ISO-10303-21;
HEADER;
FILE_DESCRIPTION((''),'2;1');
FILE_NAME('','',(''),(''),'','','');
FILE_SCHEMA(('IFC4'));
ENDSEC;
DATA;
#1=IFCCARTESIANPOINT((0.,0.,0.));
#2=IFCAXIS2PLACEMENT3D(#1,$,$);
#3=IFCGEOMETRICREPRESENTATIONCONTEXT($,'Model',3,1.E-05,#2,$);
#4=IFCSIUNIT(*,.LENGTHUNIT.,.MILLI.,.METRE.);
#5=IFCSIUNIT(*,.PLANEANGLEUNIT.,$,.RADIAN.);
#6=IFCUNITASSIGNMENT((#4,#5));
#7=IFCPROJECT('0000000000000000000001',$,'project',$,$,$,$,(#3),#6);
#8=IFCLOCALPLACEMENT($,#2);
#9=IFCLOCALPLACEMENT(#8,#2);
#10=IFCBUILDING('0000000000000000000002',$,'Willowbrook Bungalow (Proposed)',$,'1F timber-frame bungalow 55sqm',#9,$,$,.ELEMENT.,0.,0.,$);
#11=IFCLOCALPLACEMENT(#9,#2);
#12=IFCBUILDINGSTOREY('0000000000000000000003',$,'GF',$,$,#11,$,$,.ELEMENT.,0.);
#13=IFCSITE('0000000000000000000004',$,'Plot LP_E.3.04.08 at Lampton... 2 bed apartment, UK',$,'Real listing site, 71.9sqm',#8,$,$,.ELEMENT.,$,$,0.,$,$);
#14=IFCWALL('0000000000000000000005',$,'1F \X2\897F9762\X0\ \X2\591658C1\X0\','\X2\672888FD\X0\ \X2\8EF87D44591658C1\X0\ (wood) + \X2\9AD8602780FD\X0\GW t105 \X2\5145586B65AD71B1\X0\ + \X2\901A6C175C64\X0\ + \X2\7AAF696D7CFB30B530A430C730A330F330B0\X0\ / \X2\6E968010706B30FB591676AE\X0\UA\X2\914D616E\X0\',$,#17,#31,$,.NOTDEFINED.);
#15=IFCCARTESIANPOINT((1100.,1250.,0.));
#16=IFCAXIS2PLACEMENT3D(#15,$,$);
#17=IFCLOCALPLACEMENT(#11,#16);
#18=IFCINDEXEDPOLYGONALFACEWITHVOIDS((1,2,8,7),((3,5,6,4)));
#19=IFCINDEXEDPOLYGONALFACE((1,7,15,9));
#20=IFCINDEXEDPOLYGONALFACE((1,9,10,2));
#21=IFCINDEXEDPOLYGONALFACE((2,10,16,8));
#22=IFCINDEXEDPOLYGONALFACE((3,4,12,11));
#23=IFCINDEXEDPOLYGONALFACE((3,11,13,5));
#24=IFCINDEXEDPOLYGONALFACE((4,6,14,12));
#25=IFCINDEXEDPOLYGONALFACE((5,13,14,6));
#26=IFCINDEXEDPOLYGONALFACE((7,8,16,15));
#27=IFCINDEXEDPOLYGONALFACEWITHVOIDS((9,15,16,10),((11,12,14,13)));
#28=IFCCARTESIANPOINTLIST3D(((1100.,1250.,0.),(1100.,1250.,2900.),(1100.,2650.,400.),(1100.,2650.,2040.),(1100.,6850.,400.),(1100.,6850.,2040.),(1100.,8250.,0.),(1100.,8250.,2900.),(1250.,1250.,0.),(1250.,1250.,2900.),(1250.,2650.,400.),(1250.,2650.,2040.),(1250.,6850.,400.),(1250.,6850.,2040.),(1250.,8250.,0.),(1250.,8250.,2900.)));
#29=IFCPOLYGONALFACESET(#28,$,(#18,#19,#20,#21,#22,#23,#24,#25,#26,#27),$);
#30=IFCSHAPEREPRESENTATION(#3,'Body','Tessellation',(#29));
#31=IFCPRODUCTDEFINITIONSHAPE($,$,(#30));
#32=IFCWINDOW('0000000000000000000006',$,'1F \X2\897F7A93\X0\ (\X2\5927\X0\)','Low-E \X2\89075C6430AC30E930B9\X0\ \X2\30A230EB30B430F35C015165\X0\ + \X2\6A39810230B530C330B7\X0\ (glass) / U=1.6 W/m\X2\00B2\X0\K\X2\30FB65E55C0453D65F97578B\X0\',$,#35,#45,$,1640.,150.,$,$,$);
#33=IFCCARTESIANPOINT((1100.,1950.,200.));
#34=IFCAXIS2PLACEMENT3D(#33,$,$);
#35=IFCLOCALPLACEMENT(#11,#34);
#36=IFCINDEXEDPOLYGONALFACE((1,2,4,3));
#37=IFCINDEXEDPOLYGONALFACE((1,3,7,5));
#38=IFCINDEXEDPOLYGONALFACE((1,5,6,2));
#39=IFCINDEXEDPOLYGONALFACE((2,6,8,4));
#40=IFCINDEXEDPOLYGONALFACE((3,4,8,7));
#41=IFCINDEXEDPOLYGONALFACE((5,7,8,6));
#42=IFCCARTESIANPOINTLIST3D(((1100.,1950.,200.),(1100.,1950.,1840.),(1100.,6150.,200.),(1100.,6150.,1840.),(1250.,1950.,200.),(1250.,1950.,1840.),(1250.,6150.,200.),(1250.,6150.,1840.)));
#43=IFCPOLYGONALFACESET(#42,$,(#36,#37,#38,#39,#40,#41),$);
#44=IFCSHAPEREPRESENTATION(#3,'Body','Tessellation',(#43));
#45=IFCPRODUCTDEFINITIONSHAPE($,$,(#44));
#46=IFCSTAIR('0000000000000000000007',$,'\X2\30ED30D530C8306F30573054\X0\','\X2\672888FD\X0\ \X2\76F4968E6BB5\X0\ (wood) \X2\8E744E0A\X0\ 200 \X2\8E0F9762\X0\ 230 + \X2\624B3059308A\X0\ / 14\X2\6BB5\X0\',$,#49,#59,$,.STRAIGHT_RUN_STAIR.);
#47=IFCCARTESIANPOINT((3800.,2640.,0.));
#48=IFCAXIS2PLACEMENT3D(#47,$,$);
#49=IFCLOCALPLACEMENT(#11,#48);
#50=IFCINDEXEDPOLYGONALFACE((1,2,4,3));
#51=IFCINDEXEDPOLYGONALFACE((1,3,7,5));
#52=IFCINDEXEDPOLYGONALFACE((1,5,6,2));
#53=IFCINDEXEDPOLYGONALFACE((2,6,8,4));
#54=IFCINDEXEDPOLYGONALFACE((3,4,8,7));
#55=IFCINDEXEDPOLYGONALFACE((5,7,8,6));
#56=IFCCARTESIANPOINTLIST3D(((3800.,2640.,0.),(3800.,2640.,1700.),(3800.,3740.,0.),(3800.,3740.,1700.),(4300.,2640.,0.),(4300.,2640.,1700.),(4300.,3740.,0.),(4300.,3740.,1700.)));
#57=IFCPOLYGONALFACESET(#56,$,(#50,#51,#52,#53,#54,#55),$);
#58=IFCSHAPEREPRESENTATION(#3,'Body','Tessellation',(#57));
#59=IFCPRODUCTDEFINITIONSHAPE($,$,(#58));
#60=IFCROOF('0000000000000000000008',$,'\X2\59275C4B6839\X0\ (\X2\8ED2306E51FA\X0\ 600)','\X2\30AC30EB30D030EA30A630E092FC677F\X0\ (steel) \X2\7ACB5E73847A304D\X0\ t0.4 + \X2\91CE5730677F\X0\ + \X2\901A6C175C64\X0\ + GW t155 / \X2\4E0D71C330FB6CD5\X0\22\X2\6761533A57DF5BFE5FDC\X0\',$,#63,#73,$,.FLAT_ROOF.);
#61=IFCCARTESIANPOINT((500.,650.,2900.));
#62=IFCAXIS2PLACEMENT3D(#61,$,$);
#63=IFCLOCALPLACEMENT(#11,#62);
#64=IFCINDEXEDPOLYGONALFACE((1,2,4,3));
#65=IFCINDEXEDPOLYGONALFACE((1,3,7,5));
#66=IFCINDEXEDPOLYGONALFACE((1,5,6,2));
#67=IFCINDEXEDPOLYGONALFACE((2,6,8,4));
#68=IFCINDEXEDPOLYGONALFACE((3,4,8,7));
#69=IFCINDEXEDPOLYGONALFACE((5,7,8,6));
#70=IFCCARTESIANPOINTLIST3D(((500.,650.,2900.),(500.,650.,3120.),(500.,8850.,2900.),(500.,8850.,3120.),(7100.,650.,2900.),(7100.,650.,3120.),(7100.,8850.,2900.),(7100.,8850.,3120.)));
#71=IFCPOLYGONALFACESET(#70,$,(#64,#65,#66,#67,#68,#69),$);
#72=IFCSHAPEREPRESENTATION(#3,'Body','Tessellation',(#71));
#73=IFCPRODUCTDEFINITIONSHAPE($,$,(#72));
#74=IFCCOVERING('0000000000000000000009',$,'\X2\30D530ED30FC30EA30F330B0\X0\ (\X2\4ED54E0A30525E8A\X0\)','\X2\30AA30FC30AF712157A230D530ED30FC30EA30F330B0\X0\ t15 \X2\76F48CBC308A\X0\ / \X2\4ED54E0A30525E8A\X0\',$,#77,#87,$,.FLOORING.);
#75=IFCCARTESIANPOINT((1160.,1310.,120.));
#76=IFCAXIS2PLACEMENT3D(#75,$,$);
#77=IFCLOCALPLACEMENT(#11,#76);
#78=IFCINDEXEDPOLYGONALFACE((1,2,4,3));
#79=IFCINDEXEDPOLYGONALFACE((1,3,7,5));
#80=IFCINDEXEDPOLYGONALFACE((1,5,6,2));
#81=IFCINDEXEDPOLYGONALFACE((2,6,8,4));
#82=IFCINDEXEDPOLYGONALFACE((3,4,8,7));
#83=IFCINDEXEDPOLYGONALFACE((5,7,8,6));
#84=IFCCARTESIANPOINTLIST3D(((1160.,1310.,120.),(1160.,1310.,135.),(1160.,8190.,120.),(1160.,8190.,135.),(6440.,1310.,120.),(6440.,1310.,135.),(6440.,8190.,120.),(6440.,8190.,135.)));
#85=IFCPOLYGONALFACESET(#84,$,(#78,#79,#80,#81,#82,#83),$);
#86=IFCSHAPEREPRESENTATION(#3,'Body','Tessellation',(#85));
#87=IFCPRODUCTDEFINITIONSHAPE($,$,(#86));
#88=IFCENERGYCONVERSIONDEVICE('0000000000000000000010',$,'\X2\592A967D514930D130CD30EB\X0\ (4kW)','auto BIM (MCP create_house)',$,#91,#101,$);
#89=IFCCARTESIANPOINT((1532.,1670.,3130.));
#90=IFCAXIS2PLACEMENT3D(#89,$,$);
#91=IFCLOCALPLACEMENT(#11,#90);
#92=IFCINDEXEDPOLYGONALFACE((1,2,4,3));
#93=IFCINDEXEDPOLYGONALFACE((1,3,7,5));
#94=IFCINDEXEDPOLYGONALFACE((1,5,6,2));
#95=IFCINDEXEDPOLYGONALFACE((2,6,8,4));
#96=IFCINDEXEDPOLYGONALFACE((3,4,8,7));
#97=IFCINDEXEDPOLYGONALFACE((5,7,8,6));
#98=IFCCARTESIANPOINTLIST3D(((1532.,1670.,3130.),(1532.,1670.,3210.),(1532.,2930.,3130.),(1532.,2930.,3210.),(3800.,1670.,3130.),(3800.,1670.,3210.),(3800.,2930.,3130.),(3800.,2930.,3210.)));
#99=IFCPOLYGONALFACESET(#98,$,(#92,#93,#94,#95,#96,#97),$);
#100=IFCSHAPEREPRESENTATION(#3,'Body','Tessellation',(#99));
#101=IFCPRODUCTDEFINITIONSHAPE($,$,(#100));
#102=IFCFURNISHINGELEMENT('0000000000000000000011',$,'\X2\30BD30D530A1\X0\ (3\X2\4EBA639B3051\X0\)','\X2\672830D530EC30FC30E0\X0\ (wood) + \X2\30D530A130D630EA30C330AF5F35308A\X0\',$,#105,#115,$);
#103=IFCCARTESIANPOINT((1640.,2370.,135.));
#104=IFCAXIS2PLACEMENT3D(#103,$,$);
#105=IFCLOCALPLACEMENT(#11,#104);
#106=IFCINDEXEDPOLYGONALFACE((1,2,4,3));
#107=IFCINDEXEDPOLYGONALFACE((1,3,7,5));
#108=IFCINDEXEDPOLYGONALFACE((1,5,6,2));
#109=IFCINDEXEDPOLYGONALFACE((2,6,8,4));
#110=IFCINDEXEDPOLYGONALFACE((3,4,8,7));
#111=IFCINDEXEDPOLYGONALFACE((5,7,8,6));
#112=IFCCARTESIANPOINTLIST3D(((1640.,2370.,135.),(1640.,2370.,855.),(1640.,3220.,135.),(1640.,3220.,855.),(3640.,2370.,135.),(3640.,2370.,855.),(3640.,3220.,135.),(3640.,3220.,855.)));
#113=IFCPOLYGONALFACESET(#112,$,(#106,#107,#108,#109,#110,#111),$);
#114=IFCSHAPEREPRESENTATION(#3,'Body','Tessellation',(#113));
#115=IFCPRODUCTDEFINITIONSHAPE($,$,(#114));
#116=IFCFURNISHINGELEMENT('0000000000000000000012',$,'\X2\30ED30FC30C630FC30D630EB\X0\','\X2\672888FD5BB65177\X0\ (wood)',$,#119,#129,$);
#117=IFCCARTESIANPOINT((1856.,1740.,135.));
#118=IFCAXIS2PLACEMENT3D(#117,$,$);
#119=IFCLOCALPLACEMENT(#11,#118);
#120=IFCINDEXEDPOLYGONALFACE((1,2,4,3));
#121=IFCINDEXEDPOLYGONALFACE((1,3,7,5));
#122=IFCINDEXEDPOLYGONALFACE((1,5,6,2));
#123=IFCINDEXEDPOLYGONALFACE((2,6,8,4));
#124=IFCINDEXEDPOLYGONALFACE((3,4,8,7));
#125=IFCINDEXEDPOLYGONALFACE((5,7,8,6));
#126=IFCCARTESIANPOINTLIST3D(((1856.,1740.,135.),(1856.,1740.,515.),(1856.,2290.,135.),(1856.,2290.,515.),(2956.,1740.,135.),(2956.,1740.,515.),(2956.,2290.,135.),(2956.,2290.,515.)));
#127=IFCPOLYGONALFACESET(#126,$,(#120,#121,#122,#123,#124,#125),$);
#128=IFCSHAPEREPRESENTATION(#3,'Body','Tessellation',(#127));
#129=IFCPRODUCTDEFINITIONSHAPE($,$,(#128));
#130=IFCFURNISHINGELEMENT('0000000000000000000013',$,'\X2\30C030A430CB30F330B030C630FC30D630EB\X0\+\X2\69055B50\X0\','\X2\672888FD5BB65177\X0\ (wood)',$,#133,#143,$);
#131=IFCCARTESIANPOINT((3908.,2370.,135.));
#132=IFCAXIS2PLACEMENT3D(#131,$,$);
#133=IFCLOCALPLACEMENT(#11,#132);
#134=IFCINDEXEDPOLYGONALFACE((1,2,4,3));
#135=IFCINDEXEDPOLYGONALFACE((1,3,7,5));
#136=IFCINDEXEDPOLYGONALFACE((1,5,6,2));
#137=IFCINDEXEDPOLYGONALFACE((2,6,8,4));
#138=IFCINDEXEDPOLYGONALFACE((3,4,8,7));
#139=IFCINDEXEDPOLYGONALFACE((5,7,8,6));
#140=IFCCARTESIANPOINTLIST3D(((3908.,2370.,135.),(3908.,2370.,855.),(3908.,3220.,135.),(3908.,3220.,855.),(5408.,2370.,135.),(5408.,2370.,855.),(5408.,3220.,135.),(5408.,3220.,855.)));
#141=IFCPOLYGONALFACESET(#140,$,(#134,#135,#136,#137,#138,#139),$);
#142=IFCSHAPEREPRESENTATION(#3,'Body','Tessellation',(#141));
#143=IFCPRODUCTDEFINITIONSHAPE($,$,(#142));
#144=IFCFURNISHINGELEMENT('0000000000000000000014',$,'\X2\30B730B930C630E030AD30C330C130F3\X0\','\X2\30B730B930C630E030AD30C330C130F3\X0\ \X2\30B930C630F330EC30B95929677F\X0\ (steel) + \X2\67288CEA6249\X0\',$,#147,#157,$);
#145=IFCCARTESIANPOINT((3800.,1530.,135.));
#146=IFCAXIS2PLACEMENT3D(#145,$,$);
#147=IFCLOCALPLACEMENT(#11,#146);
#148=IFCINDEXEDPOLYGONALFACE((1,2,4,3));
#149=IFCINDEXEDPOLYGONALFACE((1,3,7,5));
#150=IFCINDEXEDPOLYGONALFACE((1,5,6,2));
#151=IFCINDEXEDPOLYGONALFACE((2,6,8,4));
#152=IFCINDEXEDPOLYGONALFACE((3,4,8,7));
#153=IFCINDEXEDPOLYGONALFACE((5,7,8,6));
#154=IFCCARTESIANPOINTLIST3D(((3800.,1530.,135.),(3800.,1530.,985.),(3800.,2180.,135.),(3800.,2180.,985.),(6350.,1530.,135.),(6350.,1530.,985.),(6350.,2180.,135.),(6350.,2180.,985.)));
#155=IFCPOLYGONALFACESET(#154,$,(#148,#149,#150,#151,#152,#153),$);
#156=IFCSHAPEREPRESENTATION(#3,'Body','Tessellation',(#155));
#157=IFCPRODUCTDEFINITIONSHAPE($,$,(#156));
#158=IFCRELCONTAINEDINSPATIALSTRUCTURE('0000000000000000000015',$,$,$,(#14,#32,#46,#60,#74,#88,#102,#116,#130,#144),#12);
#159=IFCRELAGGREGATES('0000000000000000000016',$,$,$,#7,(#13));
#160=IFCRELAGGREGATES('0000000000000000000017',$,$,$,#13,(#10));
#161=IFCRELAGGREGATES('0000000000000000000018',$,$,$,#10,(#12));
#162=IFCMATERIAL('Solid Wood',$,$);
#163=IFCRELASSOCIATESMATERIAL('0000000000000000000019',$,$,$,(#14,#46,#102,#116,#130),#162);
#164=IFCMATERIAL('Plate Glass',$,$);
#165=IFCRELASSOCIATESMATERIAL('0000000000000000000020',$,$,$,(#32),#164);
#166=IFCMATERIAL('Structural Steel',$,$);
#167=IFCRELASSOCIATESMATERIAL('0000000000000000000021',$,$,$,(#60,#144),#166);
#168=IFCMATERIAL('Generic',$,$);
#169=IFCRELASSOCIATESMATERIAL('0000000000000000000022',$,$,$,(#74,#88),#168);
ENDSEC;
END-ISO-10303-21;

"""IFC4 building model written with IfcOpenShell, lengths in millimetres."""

from ifc_helpers import new_model, si_unit, frame, frame_2d, origin, place, context, project, spatial, rectangle, extrude, material, element, fill, save


model = new_model("IFC4")

# Units and contexts
model_context = context("Model", 3, precision=1e-05, world=origin())
ifc_project = project(units=[si_unit("LENGTHUNIT", "METRE", prefix="MILLI"), si_unit("PLANEANGLEUNIT", "RADIAN")], contexts=[model_context])

# Site, building, storey
site_placement = place(None, origin())
site = spatial("IfcSite", under=ifc_project, at=site_placement, Name="Plot LP_E.3.04.08 at Lampton... 2 bed apartment, UK", ObjectType="Real listing site, 71.9sqm", CompositionType="ELEMENT", RefElevation=0.0)
building_placement = place(site_placement, origin())
building = spatial("IfcBuilding", under=site, at=building_placement, Name="Willowbrook Bungalow (Proposed)", ObjectType="1F timber-frame bungalow 55sqm", CompositionType="ELEMENT", ElevationOfRefHeight=0.0, ElevationOfTerrain=0.0)
storey_placement = place(building_placement, origin())
storey = spatial("IfcBuildingStorey", under=building, at=storey_placement, Name="GF", CompositionType="ELEMENT", Elevation=0.0)

# Shared definitions
ifc_material_1 = material(Name="Solid Wood")
ifc_material_2 = material(Name="Generic")

# Shared definitions
ifc_material_3 = material(Name="Plate Glass")

# Wall, opening, window
wall_1_placement = place(storey_placement, frame((1100.0, 1250.0, 0.0)))
wall_1 = element("IfcWall", 1, at=wall_1_placement, inside=storey, material=ifc_material_1, Name="1F 西面 外壁", Description="木製 軸組外壁 (wood) + 高性能GW t105 充填断熱 + 通気層 + 窯業系サイディング / 準耐火・外皮UA配慮", PredefinedType="NOTDEFINED", context=model_context, shape_type="SweptSolid", body=[
    extrude(rectangle(XDim=150.0, YDim=7000.0, at=frame_2d((75.0, 3500.0))), frame((1100.0, 1250.0, 0.0)), (0.0, 0.0, 1.0), 2900.0),
])
opening_1_placement = place(storey_placement, frame((1100.0, 1950.0, 200.0)))
opening_1 = element("IfcOpeningElement", 2, at=opening_1_placement, cuts=wall_1, PredefinedType="NOTDEFINED", context=model_context, shape_type="SweptSolid", body=[
    extrude(rectangle(XDim=150.0, YDim=4200.0, at=frame_2d((75.0, 2100.0))), frame((1100.0, 1950.0, 200.0)), (0.0, 0.0, 1.0), 1640.0),
])
window_1_placement = place(storey_placement, frame((1100.0, 1950.0, 200.0)))
window_1 = element("IfcWindow", 3, at=window_1_placement, inside=storey, material=ifc_material_3, Name="1F 西窓 (大)", Description="Low-E 複層ガラス アルゴン封入 + 樹脂サッシ (glass) / U=1.6 W/m²K・日射取得型", OverallHeight=1640.0, OverallWidth=150.0, context=model_context, shape_type="SweptSolid", body=[
    extrude(rectangle(XDim=150.0, YDim=4200.0, at=frame_2d((75.0, 2100.0))), frame((1100.0, 1950.0, 200.0)), (0.0, 0.0, 1.0), 1640.0),
])
fill(opening_1, window_1)

# Stair
stair_placement = place(storey_placement, frame((3800.0, 2640.0, 0.0)))
element("IfcStair", 4, at=stair_placement, inside=storey, material=ifc_material_1, Name="ロフトはしご", Description="木製 直階段 (wood) 蹴上 200 踏面 230 + 手すり / 14段", PredefinedType="STRAIGHT_RUN_STAIR", context=model_context, shape_type="SweptSolid", body=[
    extrude(rectangle(XDim=500.0, YDim=1100.0, at=frame_2d((250.0, 550.0))), frame((3800.0, 2640.0, 0.0)), (0.0, 0.0, 1.0), 1700.0),
])

# Roof
ifc_material_4 = material(Name="Structural Steel")
roof_placement = place(storey_placement, frame((500.0, 650.0, 2900.0)))
element("IfcRoof", 5, at=roof_placement, inside=storey, material=ifc_material_4, Name="大屋根 (軒の出 600)", Description="ガルバリウム鋼板 (steel) 立平葺き t0.4 + 野地板 + 通気層 + GW t155 / 不燃・法22条区域対応", PredefinedType="FLAT_ROOF", context=model_context, shape_type="SweptSolid", body=[
    extrude(rectangle(XDim=6600.0, YDim=8200.0, at=frame_2d((3300.0, 4100.0))), frame((500.0, 650.0, 2900.0)), (0.0, 0.0, 1.0), 220.0),
])

# Covering
covering_placement = place(storey_placement, frame((1160.0, 1310.0, 120.0)))
element("IfcCovering", 6, at=covering_placement, inside=storey, material=ifc_material_2, Name="フローリング (仕上げ床)", Description="オーク無垢フローリング t15 直貼り / 仕上げ床", PredefinedType="FLOORING", context=model_context, shape_type="SweptSolid", body=[
    extrude(rectangle(XDim=5280.0, YDim=6880.0, at=frame_2d((2640.0, 3440.0))), frame((1160.0, 1310.0, 120.0)), (0.0, 0.0, 1.0), 15.0),
])

# Energy conversion device
energy_conversion_device_placement = place(storey_placement, frame((1532.0, 1670.0, 3130.0)))
element("IfcEnergyConversionDevice", 7, at=energy_conversion_device_placement, inside=storey, material=ifc_material_2, Name="太陽光パネル (4kW)", Description="auto BIM (MCP create_house)", context=model_context, shape_type="SweptSolid", body=[
    extrude(rectangle(XDim=2268.0, YDim=1260.0, at=frame_2d((1134.0, 630.0))), frame((1532.0, 1670.0, 3130.0)), (0.0, 0.0, 1.0), 80.0),
])

# Furnishing elements
furnishing_1_placement = place(storey_placement, frame((1640.0, 2370.0, 135.0)))
element("IfcFurnishingElement", 8, at=furnishing_1_placement, inside=storey, material=ifc_material_1, Name="ソファ (3人掛け)", Description="木フレーム (wood) + ファブリック張り", context=model_context, shape_type="SweptSolid", body=[
    extrude(rectangle(XDim=2000.0, YDim=850.0, at=frame_2d((1000.0, 425.0))), frame((1640.0, 2370.0, 135.0)), (0.0, 0.0, 1.0), 720.0),
])
furnishing_2_placement = place(storey_placement, frame((1856.0, 1740.0, 135.0)))
element("IfcFurnishingElement", 9, at=furnishing_2_placement, inside=storey, material=ifc_material_1, Name="ローテーブル", Description="木製家具 (wood)", context=model_context, shape_type="SweptSolid", body=[
    extrude(rectangle(XDim=1100.0, YDim=550.0, at=frame_2d((550.0, 275.0))), frame((1856.0, 1740.0, 135.0)), (0.0, 0.0, 1.0), 380.0),
])
furnishing_3_placement = place(storey_placement, frame((3908.0, 2370.0, 135.0)))
element("IfcFurnishingElement", 10, at=furnishing_3_placement, inside=storey, material=ifc_material_1, Name="ダイニングテーブル+椅子", Description="木製家具 (wood)", context=model_context, shape_type="SweptSolid", body=[
    extrude(rectangle(XDim=1500.0, YDim=850.0, at=frame_2d((750.0, 425.0))), frame((3908.0, 2370.0, 135.0)), (0.0, 0.0, 1.0), 720.0),
])
furnishing_4_placement = place(storey_placement, frame((3800.0, 1530.0, 135.0)))
element("IfcFurnishingElement", 11, at=furnishing_4_placement, inside=storey, material=ifc_material_4, Name="システムキッチン", Description="システムキッチン ステンレス天板 (steel) + 木質扉", context=model_context, shape_type="SweptSolid", body=[
    extrude(rectangle(XDim=2550.0, YDim=650.0, at=frame_2d((1275.0, 325.0))), frame((3800.0, 1530.0, 135.0)), (0.0, 0.0, 1.0), 850.0),
])

save(model, "model.ifc")
